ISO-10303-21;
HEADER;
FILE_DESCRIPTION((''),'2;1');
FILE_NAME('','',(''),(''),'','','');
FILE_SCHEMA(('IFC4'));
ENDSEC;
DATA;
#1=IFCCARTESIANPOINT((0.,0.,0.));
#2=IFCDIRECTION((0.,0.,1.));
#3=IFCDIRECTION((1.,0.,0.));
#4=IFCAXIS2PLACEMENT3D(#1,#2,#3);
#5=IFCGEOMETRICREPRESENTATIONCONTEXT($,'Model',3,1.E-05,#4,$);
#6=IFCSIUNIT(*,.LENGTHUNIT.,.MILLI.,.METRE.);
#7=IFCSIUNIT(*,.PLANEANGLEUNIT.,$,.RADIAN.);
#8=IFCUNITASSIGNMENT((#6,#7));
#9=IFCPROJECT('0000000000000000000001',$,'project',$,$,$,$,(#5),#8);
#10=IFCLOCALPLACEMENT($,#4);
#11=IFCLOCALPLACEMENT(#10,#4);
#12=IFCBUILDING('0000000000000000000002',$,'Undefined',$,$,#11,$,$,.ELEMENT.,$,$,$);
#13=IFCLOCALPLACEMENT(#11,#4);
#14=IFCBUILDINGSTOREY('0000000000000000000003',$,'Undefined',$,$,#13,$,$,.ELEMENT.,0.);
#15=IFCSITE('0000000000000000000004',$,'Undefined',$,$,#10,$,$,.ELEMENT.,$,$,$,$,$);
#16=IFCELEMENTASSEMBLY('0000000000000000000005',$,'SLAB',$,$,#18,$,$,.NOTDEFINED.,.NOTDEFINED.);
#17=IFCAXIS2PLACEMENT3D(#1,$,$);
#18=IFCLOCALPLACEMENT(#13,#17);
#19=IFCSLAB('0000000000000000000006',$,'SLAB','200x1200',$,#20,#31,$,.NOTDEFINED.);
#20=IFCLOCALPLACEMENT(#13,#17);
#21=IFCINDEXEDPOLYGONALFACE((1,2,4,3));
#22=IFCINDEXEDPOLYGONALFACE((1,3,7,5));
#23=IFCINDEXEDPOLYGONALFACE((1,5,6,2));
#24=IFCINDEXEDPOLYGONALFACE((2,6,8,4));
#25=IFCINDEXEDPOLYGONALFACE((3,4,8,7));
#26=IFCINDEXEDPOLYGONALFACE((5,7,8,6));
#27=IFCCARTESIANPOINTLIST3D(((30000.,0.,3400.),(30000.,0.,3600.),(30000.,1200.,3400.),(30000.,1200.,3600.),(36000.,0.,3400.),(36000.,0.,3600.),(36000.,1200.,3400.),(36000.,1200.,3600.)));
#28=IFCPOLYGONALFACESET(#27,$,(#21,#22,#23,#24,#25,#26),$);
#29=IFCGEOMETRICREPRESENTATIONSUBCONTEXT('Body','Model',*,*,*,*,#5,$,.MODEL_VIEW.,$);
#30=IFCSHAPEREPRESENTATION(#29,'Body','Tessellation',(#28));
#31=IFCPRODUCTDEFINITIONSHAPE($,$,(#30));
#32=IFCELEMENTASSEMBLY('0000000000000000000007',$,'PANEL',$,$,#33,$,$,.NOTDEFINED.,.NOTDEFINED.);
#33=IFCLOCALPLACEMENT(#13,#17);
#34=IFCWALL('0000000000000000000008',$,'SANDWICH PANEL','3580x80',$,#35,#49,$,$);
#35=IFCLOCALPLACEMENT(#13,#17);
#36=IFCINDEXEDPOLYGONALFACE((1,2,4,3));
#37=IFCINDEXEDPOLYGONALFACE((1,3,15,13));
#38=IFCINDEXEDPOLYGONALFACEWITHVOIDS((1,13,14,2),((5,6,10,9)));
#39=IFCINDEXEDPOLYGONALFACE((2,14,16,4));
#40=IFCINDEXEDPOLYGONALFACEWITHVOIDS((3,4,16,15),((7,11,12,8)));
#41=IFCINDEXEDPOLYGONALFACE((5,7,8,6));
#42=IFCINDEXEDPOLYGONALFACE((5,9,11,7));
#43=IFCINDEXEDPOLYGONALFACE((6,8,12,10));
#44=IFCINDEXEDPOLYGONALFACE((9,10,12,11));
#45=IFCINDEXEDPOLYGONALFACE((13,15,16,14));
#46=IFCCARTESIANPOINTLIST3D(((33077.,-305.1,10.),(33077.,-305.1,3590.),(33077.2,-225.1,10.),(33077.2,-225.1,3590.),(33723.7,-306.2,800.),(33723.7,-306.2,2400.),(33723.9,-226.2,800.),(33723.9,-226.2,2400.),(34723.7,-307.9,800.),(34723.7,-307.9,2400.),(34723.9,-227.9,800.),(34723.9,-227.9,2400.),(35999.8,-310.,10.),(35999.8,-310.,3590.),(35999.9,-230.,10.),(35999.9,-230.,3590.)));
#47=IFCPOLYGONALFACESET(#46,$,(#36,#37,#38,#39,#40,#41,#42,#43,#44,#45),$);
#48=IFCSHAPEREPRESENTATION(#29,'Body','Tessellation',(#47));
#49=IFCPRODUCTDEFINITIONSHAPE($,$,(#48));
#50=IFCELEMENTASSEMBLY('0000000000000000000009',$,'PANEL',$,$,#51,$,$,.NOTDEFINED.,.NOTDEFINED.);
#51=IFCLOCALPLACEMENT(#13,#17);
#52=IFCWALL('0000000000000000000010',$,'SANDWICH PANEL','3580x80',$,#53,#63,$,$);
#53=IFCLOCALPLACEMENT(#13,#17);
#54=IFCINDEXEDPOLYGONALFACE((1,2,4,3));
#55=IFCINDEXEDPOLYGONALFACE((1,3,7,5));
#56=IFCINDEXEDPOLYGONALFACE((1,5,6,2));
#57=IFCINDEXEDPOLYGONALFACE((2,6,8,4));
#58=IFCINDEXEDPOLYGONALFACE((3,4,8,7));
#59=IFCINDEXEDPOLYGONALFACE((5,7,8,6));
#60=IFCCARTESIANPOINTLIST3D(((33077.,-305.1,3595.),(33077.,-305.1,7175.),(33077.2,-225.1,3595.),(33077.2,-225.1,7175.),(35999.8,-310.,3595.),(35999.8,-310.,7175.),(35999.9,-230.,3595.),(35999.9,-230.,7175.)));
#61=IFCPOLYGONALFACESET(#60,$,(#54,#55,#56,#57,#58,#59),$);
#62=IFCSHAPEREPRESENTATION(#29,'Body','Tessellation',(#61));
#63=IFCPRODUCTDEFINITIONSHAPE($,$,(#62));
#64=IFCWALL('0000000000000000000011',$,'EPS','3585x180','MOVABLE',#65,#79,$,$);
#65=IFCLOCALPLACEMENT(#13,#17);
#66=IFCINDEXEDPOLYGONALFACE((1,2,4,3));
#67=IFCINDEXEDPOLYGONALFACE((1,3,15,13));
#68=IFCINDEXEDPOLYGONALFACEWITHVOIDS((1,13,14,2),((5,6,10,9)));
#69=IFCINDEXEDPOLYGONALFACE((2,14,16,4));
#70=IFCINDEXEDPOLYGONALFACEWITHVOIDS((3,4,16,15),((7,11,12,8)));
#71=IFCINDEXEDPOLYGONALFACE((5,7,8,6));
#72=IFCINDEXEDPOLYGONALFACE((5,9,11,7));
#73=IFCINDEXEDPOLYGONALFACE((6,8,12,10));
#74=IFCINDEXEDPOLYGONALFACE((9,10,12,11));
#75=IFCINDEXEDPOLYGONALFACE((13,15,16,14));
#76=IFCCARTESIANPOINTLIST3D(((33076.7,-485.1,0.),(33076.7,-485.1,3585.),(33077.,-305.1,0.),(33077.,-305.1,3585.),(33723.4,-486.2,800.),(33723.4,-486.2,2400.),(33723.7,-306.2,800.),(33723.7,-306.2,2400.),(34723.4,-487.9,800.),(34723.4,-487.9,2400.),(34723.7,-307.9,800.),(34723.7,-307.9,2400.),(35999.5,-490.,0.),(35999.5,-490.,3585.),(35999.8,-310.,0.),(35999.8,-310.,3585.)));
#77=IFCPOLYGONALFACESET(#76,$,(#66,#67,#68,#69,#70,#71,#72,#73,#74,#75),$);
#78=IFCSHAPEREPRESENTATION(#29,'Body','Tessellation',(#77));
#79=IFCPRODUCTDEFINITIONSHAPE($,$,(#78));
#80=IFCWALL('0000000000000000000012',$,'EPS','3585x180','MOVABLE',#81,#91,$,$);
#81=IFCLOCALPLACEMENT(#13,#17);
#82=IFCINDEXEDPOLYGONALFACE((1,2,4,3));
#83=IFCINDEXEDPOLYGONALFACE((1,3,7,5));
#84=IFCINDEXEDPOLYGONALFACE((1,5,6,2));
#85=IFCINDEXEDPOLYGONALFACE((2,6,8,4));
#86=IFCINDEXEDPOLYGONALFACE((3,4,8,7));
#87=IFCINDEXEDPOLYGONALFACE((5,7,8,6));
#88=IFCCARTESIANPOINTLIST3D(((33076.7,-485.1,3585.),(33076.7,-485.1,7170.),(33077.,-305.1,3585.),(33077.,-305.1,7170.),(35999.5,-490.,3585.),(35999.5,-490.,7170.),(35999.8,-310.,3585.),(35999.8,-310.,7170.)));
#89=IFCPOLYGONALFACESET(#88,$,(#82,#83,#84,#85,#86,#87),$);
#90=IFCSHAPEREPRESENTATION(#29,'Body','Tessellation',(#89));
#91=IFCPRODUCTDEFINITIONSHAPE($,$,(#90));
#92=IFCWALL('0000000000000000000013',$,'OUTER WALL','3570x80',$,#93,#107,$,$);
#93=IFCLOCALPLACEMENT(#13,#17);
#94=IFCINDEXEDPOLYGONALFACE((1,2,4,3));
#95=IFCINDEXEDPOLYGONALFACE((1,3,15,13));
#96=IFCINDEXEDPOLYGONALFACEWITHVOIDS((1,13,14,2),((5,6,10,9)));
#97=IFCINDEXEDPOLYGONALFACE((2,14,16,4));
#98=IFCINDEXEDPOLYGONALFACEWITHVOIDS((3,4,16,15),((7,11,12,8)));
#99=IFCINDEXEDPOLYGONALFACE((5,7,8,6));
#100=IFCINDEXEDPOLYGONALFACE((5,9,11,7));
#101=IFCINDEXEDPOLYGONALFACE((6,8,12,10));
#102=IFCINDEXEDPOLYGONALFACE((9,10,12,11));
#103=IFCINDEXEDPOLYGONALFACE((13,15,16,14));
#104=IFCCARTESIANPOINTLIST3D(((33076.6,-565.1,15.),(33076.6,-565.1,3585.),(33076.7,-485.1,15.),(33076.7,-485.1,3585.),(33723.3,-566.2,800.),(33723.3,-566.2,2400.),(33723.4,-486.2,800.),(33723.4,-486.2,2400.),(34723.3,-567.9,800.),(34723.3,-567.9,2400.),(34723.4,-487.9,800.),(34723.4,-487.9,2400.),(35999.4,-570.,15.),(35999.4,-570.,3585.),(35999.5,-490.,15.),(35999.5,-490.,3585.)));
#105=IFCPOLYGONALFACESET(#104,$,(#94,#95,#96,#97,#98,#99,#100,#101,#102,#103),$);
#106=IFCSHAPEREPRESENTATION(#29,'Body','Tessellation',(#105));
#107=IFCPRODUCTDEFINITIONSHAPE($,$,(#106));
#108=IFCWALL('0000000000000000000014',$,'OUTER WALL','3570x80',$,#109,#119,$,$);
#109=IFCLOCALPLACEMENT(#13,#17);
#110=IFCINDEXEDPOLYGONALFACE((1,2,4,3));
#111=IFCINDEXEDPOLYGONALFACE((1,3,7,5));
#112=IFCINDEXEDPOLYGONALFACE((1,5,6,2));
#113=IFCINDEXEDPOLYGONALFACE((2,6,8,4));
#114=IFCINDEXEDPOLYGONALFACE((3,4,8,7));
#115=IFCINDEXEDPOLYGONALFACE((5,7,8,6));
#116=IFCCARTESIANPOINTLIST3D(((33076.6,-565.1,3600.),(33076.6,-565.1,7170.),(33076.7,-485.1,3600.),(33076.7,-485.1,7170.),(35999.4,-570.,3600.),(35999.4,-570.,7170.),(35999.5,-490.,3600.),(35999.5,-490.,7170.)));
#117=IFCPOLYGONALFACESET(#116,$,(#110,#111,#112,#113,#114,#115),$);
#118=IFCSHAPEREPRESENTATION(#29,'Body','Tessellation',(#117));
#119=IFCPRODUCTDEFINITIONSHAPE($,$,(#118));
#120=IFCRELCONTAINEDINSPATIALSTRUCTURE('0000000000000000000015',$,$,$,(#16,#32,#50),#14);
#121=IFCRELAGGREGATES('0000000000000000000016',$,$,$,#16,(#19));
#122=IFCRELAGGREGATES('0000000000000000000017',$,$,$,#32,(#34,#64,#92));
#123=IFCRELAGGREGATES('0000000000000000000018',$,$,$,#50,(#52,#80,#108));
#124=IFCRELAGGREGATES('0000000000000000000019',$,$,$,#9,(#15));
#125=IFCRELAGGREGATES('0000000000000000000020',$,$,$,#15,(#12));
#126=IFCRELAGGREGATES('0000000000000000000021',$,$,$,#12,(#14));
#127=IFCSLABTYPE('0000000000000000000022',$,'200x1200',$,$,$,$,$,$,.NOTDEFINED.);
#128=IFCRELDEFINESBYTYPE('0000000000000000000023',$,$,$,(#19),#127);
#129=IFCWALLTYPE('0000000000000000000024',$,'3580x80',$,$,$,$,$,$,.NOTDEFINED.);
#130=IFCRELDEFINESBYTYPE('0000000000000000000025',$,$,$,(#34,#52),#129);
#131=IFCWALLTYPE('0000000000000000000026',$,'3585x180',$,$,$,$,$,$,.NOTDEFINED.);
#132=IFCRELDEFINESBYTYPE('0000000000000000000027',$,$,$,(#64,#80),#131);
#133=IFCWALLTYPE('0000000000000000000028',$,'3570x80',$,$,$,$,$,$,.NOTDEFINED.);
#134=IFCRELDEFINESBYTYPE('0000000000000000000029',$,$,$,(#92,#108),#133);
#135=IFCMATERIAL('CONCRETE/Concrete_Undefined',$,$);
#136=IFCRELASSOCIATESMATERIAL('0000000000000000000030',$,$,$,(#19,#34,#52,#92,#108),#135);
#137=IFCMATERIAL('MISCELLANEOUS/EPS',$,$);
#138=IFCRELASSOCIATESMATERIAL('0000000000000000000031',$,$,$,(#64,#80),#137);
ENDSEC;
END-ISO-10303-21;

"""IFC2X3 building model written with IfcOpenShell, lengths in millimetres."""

from ifc_helpers import new_model, si_unit, frame, frame_2d, origin_with_axes, place, context, subcontext, project, spatial, polyline, rectangle, outline, extrude, material, type_object, element, aggregate, save


model = new_model("IFC2X3")

# Units and contexts
model_context = context("Model", 3, precision=1e-05, world=origin_with_axes())
body_context = subcontext(model_context, "Body", "Model", "MODEL_VIEW")
ifc_project = project(units=[si_unit("LENGTHUNIT", "METRE", prefix="MILLI"), si_unit("PLANEANGLEUNIT", "RADIAN")], contexts=[model_context])

# Site, building, storey
site_placement = place(None, origin_with_axes())
site = spatial("IfcSite", under=ifc_project, at=site_placement, Name="Undefined", CompositionType="ELEMENT")
building_placement = place(site_placement, origin_with_axes())
building = spatial("IfcBuilding", under=site, at=building_placement, Name="Undefined", CompositionType="ELEMENT")
storey_placement = place(building_placement, origin_with_axes())
storey = spatial("IfcBuildingStorey", under=building, at=storey_placement, Name="Undefined", CompositionType="ELEMENT", Elevation=0.0)

# Shared definitions
ifc_material_1 = material(Name="CONCRETE/Concrete_Undefined")

# Element assembly, slab
slab_type = type_object("IfcSlabType", Name="200x1200", PredefinedType="NOTDEFINED")
assembly_1_placement = place(storey_placement, origin_with_axes())
assembly_1 = element("IfcElementAssembly", 1, at=assembly_1_placement, inside=storey, Name="SLAB", AssemblyPlace="NOTDEFINED", PredefinedType="NOTDEFINED")
slab_1_placement = place(assembly_1_placement, frame((36000.0, 0.0, 3500.0), z_axis=(0.0, 0.0, 1.0), x_axis=(0.0, 1.0, 0.0)))
slab_1 = element("IfcSlab", 2, at=slab_1_placement, type_object=slab_type, material=ifc_material_1, Name="SLAB", Description="200x1200", PredefinedType="NOTDEFINED", context=body_context, shape_type="SweptSolid", body=[
    extrude(outline(polyline([(0.0, 0.0), (1200.0, 0.0), (1200.0, 6000.0), (0.0, 6000.0), (0.0, 0.0)])), frame((0.0, 0.0, -100.0), z_axis=(0.0, 0.0, 1.0), x_axis=(1.0, 0.0, 0.0)), (0.0, 0.0, 1.0), 200.0),
])
aggregate(assembly_1, [slab_1])

# Element assembly, wall, opening
assembly_2_placement = place(storey_placement, origin_with_axes())
assembly_2 = element("IfcElementAssembly", 3, at=assembly_2_placement, inside=storey, Name="PANEL", AssemblyPlace="NOTDEFINED", PredefinedType="NOTDEFINED")
wall_type_1 = type_object("IfcWallType", Name="3580x80", PredefinedType="NOTDEFINED")
wall_1_placement = place(assembly_2_placement, frame((33077.1, -265.1, 10.0), z_axis=(0.0, 0.0, 1.0), x_axis=(0.999999, -0.001684, 0.0)))
wall_1 = element("IfcWall", 4, at=wall_1_placement, type_object=wall_type_1, material=ifc_material_1, Name="SANDWICH PANEL", Description="3580x80", context=body_context, shape_type="SweptSolid", body=[
    extrude(rectangle(XDim=2922.8, YDim=80.0, at=frame_2d((0.0, 1461.4), x_axis=(0.0, -1.0))), frame((0.0, 0.0, 0.0), z_axis=(0.0, 0.0, 1.0), x_axis=(0.0, -1.0, 0.0)), (0.0, 0.0, 1.0), 3580.0),
])
opening_1_placement = place(assembly_2_placement, frame((33077.1, -265.1, 10.0), z_axis=(0.0, 0.0, 1.0), x_axis=(0.999999, -0.001684, 0.0)))
element("IfcOpeningElement", 5, at=opening_1_placement, cuts=wall_1, ObjectType="Recess", context=body_context, shape_type="SweptSolid", body=[
    extrude(outline(polyline([(0.0, 0.0), (1000.0, 0.0), (1000.0, 1600.0), (0.0, 1600.0), (0.0, 0.0)])), frame((646.7, 90.0, 790.0), z_axis=(0.0, -1.0, 0.0), x_axis=(1.0, 0.0, 0.0)), (0.0, 0.0, 1.0), 180.0),
])

# Element assembly, wall
assembly_3_placement = place(storey_placement, origin_with_axes())
assembly_3 = element("IfcElementAssembly", 6, at=assembly_3_placement, inside=storey, Name="PANEL", AssemblyPlace="NOTDEFINED", PredefinedType="NOTDEFINED")
wall_2_placement = place(assembly_3_placement, frame((33077.1, -265.1, 3595.0), z_axis=(0.0, 0.0, 1.0), x_axis=(0.999999, -0.001684, 0.0)))
wall_2 = element("IfcWall", 7, at=wall_2_placement, type_object=wall_type_1, material=ifc_material_1, Name="SANDWICH PANEL", Description="3580x80", context=body_context, shape_type="SweptSolid", body=[
    extrude(rectangle(XDim=2922.8, YDim=80.0, at=frame_2d((0.0, 1461.4), x_axis=(0.0, -1.0))), frame((0.0, 0.0, 0.0), z_axis=(0.0, 0.0, 1.0), x_axis=(0.0, -1.0, 0.0)), (0.0, 0.0, 1.0), 3580.0),
])

# Wall, opening
ifc_material_2 = material(Name="MISCELLANEOUS/EPS")
wall_type_2 = type_object("IfcWallType", Name="3585x180", PredefinedType="NOTDEFINED")
wall_3_placement = place(assembly_2_placement, frame((33076.9, -395.1, 0.0), z_axis=(0.0, 0.0, 1.0), x_axis=(0.999999, -0.001684, 0.0)))
wall_3 = element("IfcWall", 8, at=wall_3_placement, type_object=wall_type_2, material=ifc_material_2, Name="EPS", Description="3585x180", ObjectType="MOVABLE", context=body_context, shape_type="SweptSolid", body=[
    extrude(rectangle(XDim=2922.8, YDim=180.0, at=frame_2d((0.0, 1461.4), x_axis=(0.0, -1.0))), frame((0.0, 0.0, 0.0), z_axis=(0.0, 0.0, 1.0), x_axis=(0.0, -1.0, 0.0)), (0.0, 0.0, 1.0), 3585.0),
])
opening_2_placement = place(assembly_2_placement, frame((33076.9, -395.1, 0.0), z_axis=(0.0, 0.0, 1.0), x_axis=(0.999999, -0.001684, 0.0)))
element("IfcOpeningElement", 9, at=opening_2_placement, cuts=wall_3, ObjectType="Recess", context=body_context, shape_type="SweptSolid", body=[
    extrude(outline(polyline([(0.0, 0.0), (1000.0, 0.0), (1000.0, 1600.0), (0.0, 1600.0), (0.0, 0.0)])), frame((646.7, 140.0, 800.0), z_axis=(0.0, -1.0, 0.0), x_axis=(1.0, 0.0, 0.0)), (0.0, 0.0, 1.0), 280.0),
])

# Wall
wall_4_placement = place(assembly_3_placement, frame((33076.9, -395.1, 3585.0), z_axis=(0.0, 0.0, 1.0), x_axis=(0.999999, -0.001684, 0.0)))
wall_4 = element("IfcWall", 10, at=wall_4_placement, type_object=wall_type_2, material=ifc_material_2, Name="EPS", Description="3585x180", ObjectType="MOVABLE", context=body_context, shape_type="SweptSolid", body=[
    extrude(rectangle(XDim=2922.8, YDim=180.0, at=frame_2d((0.0, 1461.4), x_axis=(0.0, -1.0))), frame((0.0, 0.0, 0.0), z_axis=(0.0, 0.0, 1.0), x_axis=(0.0, -1.0, 0.0)), (0.0, 0.0, 1.0), 3585.0),
])

# Wall, opening
wall_type_3 = type_object("IfcWallType", Name="3570x80", PredefinedType="NOTDEFINED")
wall_5_placement = place(assembly_2_placement, frame((33076.6, -525.1, 15.0), z_axis=(0.0, 0.0, 1.0), x_axis=(0.999999, -0.001684, 0.0)))
wall_5 = element("IfcWall", 11, at=wall_5_placement, type_object=wall_type_3, material=ifc_material_1, Name="OUTER WALL", Description="3570x80", context=body_context, shape_type="SweptSolid", body=[
    extrude(rectangle(XDim=2922.8, YDim=80.0, at=frame_2d((0.0, 1461.4), x_axis=(0.0, -1.0))), frame((0.0, 0.0, 0.0), z_axis=(0.0, 0.0, 1.0), x_axis=(0.0, -1.0, 0.0)), (0.0, 0.0, 1.0), 3570.0),
])
opening_3_placement = place(assembly_2_placement, frame((33076.6, -525.1, 15.0), z_axis=(0.0, 0.0, 1.0), x_axis=(0.999999, -0.001684, 0.0)))
element("IfcOpeningElement", 12, at=opening_3_placement, cuts=wall_5, ObjectType="Recess", context=body_context, shape_type="SweptSolid", body=[
    extrude(outline(polyline([(0.0, 0.0), (1000.0, 0.0), (1000.0, 1600.0), (0.0, 1600.0), (0.0, 0.0)])), frame((646.7, 90.0, 785.0), z_axis=(0.0, -1.0, 0.0), x_axis=(1.0, 0.0, 0.0)), (0.0, 0.0, 1.0), 180.0),
])
aggregate(assembly_2, [wall_1, wall_3, wall_5])

# Wall
wall_6_placement = place(assembly_3_placement, frame((33076.6, -525.1, 3600.0), z_axis=(0.0, 0.0, 1.0), x_axis=(0.999999, -0.001684, 0.0)))
wall_6 = element("IfcWall", 13, at=wall_6_placement, type_object=wall_type_3, material=ifc_material_1, Name="OUTER WALL", Description="3570x80", context=body_context, shape_type="SweptSolid", body=[
    extrude(rectangle(XDim=2922.8, YDim=80.0, at=frame_2d((0.0, 1461.4), x_axis=(0.0, -1.0))), frame((0.0, 0.0, 0.0), z_axis=(0.0, 0.0, 1.0), x_axis=(0.0, -1.0, 0.0)), (0.0, 0.0, 1.0), 3570.0),
])
aggregate(assembly_3, [wall_2, wall_4, wall_6])

save(model, "model.ifc")
